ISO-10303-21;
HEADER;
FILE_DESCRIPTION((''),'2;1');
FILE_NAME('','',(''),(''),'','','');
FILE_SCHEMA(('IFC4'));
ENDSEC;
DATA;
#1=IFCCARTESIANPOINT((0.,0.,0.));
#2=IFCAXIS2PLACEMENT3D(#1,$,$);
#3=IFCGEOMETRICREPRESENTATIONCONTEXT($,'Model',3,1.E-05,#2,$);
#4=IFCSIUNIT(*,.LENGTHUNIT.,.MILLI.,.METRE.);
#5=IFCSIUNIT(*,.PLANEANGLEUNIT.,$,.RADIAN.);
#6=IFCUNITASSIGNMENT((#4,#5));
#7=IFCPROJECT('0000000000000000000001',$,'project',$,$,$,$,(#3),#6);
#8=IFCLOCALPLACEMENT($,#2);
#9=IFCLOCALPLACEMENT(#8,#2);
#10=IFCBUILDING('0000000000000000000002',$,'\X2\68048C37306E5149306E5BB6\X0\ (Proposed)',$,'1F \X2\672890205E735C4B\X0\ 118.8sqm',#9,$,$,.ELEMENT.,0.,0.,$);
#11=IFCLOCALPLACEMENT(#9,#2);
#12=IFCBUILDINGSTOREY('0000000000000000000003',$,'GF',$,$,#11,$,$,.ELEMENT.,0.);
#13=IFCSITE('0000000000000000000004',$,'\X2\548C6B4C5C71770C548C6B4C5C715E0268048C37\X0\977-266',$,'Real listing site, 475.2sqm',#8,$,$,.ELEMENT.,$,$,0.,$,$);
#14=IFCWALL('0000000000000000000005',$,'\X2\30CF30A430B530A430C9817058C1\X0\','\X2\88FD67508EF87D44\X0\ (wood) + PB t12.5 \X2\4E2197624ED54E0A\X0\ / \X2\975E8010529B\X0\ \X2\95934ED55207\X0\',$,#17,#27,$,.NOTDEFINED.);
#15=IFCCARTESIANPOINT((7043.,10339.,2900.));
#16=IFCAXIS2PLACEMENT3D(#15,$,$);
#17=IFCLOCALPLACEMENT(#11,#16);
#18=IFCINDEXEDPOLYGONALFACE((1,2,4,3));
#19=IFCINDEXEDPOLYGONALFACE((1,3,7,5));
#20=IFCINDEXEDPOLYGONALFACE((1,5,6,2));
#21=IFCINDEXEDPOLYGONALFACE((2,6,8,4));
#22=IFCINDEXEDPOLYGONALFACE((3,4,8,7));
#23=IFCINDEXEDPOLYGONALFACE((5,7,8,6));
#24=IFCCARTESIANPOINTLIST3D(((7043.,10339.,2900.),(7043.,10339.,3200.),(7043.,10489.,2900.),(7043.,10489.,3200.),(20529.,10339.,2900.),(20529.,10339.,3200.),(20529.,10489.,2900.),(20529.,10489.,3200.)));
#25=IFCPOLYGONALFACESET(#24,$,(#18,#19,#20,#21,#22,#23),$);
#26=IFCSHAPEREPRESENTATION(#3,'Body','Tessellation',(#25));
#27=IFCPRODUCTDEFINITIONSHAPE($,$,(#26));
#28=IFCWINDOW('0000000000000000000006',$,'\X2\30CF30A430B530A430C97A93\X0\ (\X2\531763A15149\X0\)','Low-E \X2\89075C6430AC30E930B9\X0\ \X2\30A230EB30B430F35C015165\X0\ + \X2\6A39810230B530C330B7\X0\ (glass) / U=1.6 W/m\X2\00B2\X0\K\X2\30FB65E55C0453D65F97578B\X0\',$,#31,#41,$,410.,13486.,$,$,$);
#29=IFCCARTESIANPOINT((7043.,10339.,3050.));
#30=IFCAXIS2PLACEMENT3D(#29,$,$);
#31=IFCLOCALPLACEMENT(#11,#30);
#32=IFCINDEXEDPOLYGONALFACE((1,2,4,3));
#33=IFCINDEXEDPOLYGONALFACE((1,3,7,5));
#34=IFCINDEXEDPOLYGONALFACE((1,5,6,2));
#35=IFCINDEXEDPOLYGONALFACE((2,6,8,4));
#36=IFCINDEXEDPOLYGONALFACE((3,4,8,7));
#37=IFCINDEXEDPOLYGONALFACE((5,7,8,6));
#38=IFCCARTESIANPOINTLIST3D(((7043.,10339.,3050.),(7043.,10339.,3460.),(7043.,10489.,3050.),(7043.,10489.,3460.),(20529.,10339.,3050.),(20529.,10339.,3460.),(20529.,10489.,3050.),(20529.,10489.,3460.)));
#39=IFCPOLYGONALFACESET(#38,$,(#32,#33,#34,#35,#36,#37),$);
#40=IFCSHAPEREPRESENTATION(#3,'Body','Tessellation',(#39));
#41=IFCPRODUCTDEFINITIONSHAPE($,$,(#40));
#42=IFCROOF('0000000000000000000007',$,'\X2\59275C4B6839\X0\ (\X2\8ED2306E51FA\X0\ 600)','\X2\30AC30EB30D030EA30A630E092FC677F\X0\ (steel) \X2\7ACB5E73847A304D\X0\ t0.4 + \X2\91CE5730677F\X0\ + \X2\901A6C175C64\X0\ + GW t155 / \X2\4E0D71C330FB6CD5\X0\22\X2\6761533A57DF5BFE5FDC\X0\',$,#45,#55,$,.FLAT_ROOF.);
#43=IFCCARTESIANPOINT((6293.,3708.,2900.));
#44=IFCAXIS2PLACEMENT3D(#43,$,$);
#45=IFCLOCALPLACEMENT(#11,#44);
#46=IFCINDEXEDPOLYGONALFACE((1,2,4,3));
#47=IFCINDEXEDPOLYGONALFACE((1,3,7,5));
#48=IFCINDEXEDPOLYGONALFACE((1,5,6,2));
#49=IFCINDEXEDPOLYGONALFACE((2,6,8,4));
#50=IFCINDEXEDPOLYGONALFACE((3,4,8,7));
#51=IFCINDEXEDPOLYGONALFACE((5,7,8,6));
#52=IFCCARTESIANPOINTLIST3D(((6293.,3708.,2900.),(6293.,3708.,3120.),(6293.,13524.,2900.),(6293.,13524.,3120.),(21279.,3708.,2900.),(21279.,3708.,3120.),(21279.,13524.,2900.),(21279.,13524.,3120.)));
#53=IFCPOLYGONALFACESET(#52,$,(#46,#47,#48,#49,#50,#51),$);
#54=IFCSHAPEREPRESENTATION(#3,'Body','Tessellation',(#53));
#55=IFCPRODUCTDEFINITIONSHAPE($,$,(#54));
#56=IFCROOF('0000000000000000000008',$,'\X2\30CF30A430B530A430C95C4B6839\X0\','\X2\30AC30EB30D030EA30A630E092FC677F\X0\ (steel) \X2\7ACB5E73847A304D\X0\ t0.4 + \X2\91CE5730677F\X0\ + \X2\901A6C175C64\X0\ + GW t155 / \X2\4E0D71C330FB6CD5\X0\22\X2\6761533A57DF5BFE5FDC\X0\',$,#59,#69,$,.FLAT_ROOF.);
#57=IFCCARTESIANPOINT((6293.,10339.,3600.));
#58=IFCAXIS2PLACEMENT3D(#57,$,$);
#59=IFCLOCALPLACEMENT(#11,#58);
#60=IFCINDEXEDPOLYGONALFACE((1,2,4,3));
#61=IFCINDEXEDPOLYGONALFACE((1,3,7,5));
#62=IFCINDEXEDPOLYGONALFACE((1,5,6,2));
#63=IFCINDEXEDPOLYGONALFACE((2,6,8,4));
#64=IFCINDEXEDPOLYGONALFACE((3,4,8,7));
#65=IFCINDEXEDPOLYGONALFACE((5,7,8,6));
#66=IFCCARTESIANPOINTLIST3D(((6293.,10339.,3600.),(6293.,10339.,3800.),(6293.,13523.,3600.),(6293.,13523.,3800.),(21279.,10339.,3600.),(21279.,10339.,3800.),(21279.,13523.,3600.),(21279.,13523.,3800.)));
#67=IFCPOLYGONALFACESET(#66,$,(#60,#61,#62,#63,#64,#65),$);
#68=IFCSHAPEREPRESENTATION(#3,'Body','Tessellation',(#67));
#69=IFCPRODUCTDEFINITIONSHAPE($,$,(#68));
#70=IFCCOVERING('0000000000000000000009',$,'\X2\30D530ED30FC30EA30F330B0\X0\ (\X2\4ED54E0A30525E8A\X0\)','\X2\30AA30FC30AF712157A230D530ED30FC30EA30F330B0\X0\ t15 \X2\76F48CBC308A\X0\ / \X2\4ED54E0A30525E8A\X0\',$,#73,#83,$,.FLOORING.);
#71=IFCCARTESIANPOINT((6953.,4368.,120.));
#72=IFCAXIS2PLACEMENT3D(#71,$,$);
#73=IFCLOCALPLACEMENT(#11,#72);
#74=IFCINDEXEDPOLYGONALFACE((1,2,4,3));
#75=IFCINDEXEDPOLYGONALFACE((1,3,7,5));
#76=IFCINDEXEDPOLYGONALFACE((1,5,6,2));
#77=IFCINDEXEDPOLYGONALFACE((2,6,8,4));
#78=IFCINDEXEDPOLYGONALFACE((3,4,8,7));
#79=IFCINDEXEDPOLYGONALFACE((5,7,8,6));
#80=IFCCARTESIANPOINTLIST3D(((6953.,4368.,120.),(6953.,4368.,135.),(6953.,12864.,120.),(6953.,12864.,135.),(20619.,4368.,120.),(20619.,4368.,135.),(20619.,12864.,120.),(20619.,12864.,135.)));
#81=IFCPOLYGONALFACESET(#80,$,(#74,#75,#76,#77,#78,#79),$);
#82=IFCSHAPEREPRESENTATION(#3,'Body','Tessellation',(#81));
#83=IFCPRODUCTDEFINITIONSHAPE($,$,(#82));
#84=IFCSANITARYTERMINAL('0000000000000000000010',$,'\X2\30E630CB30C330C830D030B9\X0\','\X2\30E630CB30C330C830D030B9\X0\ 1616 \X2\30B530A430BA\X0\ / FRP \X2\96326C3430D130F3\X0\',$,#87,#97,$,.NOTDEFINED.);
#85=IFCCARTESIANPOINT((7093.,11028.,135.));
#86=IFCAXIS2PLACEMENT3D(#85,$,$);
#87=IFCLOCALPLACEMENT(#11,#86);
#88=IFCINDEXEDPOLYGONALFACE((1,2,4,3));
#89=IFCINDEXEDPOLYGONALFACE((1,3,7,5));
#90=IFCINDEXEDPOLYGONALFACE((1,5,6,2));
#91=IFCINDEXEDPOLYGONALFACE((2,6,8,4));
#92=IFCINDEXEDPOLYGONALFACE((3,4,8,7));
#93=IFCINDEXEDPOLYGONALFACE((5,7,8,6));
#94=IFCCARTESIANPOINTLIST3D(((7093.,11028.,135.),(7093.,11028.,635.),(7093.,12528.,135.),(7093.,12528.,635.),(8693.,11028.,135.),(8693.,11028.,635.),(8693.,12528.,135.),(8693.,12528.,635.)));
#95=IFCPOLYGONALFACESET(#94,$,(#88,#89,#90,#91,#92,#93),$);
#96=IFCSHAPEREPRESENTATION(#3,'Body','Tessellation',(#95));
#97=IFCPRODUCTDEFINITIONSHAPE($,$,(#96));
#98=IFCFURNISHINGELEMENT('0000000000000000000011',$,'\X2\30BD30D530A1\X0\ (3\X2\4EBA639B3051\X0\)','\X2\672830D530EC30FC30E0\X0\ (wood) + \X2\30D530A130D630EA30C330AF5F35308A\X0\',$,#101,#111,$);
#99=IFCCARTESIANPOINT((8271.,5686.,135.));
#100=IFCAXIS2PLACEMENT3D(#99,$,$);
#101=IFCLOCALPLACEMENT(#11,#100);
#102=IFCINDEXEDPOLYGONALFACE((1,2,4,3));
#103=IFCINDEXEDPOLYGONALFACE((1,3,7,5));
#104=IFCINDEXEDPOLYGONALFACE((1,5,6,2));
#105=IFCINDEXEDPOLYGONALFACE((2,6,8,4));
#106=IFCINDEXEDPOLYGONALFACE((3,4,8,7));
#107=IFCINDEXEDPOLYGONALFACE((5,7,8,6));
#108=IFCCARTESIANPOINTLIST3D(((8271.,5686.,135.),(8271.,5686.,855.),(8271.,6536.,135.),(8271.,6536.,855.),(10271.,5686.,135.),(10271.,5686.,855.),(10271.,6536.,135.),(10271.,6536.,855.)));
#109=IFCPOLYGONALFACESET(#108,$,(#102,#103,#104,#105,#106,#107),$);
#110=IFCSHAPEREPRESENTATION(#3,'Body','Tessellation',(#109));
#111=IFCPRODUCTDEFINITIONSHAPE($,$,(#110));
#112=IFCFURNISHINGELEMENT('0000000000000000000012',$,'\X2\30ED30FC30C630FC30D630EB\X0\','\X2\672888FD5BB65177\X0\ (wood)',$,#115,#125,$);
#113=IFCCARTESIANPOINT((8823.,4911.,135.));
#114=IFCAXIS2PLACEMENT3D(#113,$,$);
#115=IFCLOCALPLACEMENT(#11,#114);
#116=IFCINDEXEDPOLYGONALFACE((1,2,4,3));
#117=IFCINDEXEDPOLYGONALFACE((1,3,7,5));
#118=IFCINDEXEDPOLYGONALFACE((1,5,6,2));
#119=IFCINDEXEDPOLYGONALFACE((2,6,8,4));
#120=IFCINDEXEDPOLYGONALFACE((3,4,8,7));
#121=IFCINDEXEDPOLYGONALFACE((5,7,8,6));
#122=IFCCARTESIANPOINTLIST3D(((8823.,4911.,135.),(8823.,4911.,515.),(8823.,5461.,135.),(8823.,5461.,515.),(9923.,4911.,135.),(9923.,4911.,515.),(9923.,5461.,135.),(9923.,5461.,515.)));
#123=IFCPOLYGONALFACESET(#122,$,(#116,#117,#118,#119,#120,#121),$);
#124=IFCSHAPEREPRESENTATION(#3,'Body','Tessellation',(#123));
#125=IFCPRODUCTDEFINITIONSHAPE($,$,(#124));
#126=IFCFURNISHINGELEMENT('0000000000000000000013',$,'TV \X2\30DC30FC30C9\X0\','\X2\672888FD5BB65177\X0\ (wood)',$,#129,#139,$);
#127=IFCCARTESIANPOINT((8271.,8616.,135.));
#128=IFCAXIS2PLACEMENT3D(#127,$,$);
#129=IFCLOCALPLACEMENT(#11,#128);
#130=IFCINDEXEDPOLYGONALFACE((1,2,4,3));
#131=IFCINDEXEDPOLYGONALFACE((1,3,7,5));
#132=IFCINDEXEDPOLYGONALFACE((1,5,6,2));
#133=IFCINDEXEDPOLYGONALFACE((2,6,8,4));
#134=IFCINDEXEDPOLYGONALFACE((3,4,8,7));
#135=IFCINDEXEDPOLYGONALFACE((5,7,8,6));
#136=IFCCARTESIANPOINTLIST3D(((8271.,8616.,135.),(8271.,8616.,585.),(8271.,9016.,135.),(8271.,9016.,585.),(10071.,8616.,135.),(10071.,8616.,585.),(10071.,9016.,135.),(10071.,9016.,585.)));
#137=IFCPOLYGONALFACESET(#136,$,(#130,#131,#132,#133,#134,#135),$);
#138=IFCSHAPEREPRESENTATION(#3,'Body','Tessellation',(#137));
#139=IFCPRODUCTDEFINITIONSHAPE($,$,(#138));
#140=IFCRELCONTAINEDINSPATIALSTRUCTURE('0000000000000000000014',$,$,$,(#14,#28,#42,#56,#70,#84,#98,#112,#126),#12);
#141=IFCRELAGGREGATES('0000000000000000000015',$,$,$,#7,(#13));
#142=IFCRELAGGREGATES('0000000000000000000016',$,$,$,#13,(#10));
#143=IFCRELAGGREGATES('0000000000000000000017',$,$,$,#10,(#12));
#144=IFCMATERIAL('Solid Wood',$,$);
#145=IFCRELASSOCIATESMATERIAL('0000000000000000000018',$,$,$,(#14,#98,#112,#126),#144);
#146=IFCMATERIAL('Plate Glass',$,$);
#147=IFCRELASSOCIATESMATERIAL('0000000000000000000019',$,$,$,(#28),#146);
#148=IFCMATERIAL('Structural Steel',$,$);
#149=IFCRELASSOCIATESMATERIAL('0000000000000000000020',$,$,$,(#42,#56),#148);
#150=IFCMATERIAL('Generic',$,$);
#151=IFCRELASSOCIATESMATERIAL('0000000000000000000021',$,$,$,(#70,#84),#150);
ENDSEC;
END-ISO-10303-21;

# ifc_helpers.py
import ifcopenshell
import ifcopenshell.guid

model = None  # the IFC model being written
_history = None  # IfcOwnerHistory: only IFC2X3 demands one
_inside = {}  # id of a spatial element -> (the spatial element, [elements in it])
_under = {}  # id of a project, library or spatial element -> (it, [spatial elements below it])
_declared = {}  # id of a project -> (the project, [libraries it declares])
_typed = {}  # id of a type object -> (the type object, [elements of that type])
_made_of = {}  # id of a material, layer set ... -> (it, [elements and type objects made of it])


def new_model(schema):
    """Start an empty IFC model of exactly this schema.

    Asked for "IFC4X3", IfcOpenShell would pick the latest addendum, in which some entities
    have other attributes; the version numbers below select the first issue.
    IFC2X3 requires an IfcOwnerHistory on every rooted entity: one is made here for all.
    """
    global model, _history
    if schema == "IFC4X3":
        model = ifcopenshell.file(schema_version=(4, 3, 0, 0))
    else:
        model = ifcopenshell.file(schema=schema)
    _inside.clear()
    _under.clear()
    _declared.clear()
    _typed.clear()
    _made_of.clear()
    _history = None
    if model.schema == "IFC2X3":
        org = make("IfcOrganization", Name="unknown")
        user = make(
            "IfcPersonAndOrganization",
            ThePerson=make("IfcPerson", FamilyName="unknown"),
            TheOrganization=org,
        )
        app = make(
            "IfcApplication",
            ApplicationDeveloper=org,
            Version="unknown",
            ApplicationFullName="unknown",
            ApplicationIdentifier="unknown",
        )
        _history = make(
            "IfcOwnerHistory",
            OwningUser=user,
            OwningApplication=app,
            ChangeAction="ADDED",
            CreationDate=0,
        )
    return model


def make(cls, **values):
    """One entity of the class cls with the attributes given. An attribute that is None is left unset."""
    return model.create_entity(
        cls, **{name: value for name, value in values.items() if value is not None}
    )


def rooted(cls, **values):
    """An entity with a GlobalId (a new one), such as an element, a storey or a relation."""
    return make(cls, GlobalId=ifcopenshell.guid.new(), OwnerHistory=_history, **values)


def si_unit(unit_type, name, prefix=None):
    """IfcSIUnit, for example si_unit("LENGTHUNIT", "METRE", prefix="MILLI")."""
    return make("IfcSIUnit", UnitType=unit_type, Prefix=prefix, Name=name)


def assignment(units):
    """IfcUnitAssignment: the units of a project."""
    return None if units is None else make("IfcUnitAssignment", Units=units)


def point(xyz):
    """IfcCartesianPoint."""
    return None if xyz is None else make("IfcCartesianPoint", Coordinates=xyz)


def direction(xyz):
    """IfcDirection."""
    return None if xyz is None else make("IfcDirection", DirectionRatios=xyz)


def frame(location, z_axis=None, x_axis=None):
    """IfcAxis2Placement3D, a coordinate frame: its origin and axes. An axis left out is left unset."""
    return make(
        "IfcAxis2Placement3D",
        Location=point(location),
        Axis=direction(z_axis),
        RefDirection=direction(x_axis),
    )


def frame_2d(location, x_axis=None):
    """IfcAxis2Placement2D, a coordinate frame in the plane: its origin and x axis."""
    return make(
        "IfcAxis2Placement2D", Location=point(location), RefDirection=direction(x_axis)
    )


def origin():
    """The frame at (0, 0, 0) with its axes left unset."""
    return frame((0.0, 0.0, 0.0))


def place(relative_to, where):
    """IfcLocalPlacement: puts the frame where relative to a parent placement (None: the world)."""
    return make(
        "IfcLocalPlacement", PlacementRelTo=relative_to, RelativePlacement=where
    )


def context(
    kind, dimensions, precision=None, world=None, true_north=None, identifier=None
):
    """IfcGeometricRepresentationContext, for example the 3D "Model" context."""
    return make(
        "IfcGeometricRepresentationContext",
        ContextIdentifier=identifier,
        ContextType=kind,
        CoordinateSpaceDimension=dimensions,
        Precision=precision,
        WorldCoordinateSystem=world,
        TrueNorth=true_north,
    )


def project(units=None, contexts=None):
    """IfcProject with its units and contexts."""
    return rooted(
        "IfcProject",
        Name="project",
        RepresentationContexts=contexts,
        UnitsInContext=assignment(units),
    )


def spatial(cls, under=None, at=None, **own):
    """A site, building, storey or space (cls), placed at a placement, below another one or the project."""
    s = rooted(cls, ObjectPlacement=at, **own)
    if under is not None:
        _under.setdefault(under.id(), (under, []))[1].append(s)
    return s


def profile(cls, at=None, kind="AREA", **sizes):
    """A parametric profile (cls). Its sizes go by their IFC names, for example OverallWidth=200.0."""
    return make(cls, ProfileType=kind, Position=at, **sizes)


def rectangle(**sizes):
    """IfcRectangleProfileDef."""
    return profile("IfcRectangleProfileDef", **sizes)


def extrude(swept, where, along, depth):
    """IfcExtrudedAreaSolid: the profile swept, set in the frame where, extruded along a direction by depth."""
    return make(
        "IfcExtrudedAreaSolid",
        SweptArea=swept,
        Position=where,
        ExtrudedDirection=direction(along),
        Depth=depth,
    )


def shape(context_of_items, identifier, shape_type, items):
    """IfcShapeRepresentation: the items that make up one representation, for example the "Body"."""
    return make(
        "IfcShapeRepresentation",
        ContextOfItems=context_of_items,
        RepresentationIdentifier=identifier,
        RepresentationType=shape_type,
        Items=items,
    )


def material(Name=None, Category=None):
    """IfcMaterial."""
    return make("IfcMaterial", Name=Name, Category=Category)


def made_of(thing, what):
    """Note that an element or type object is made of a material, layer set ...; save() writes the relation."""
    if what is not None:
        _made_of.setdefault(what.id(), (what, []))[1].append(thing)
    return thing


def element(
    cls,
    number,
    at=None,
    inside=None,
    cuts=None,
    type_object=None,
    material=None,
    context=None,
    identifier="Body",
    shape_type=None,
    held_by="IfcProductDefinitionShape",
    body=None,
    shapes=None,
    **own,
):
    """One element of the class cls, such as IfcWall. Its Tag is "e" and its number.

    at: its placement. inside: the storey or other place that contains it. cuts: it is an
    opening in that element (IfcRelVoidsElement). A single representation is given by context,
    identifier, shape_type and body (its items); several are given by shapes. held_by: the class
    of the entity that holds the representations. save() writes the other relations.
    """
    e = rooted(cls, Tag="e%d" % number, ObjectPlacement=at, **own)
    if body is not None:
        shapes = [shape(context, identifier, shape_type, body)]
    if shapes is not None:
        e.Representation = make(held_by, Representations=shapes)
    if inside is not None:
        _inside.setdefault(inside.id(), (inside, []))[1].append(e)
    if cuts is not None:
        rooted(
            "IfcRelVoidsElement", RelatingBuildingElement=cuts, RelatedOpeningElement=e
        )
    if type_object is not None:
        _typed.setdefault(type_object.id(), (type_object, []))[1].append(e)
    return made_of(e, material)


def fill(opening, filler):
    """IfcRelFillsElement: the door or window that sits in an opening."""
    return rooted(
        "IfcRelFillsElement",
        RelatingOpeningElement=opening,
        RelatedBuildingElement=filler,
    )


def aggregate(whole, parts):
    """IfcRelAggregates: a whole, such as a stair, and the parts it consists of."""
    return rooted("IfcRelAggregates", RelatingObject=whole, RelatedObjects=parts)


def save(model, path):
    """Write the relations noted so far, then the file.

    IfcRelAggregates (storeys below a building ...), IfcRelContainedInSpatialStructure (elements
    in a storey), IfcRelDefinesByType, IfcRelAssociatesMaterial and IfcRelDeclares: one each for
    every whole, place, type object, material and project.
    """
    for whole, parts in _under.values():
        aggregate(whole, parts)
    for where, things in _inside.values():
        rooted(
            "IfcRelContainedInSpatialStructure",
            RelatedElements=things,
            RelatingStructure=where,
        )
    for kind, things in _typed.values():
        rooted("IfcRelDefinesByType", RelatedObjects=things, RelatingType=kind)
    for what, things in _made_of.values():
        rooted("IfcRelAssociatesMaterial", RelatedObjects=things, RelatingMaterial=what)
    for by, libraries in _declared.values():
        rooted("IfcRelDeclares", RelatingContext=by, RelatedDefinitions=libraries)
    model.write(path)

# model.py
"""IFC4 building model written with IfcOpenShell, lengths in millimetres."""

from ifc_helpers import new_model, si_unit, frame, frame_2d, origin, place, context, project, spatial, rectangle, extrude, material, element, fill, save


model = new_model("IFC4")

# Units and contexts
model_context = context("Model", 3, precision=1e-05, world=origin())
ifc_project = project(units=[si_unit("LENGTHUNIT", "METRE", prefix="MILLI"), si_unit("PLANEANGLEUNIT", "RADIAN")], contexts=[model_context])

# Site, building, storey
site_placement = place(None, origin())
site = spatial("IfcSite", under=ifc_project, at=site_placement, Name="和歌山県和歌山市栄谷977-266", ObjectType="Real listing site, 475.2sqm", CompositionType="ELEMENT", RefElevation=0.0)
building_placement = place(site_placement, origin())
building = spatial("IfcBuilding", under=site, at=building_placement, Name="栄谷の光の家 (Proposed)", ObjectType="1F 木造平屋 118.8sqm", CompositionType="ELEMENT", ElevationOfRefHeight=0.0, ElevationOfTerrain=0.0)
storey_placement = place(building_placement, origin())
storey = spatial("IfcBuildingStorey", under=building, at=storey_placement, Name="GF", CompositionType="ELEMENT", Elevation=0.0)

# Shared definitions
ifc_material_1 = material(Name="Solid Wood")

# Shared definitions
ifc_material_2 = material(Name="Plate Glass")

# Wall, opening, window
wall_1_placement = place(storey_placement, frame((7043.0, 10339.0, 2900.0)))
wall_1 = element("IfcWall", 1, at=wall_1_placement, inside=storey, material=ifc_material_1, Name="ハイサイド腰壁", Description="製材軸組 (wood) + PB t12.5 両面仕上 / 非耐力 間仕切", PredefinedType="NOTDEFINED", context=model_context, shape_type="SweptSolid", body=[
    extrude(rectangle(XDim=13486.0, YDim=150.0, at=frame_2d((6743.0, 75.0))), frame((7043.0, 10339.0, 2900.0)), (0.0, 0.0, 1.0), 700.0),
])
opening_1_placement = place(storey_placement, frame((7043.0, 10339.0, 3050.0)))
opening_1 = element("IfcOpeningElement", 2, at=opening_1_placement, cuts=wall_1, PredefinedType="NOTDEFINED", context=model_context, shape_type="SweptSolid", body=[
    extrude(rectangle(XDim=13486.0, YDim=150.0, at=frame_2d((6743.0, 75.0))), frame((7043.0, 10339.0, 3050.0)), (0.0, 0.0, 1.0), 410.0),
])
window_1_placement = place(storey_placement, frame((7043.0, 10339.0, 3050.0)))
window_1 = element("IfcWindow", 3, at=window_1_placement, inside=storey, material=ifc_material_2, Name="ハイサイド窓 (北採光)", Description="Low-E 複層ガラス アルゴン封入 + 樹脂サッシ (glass) / U=1.6 W/m²K・日射取得型", OverallHeight=410.0, OverallWidth=13486.0, context=model_context, shape_type="SweptSolid", body=[
    extrude(rectangle(XDim=13486.0, YDim=150.0, at=frame_2d((6743.0, 75.0))), frame((7043.0, 10339.0, 3050.0)), (0.0, 0.0, 1.0), 410.0),
])
fill(opening_1, window_1)

# Roofs
ifc_material_3 = material(Name="Structural Steel")
roof_1_placement = place(storey_placement, frame((6293.0, 3708.0, 2900.0)))
element("IfcRoof", 4, at=roof_1_placement, inside=storey, material=ifc_material_3, Name="大屋根 (軒の出 600)", Description="ガルバリウム鋼板 (steel) 立平葺き t0.4 + 野地板 + 通気層 + GW t155 / 不燃・法22条区域対応", PredefinedType="FLAT_ROOF", context=model_context, shape_type="SweptSolid", body=[
    extrude(rectangle(XDim=14986.0, YDim=9816.0, at=frame_2d((7493.0, 4908.0))), frame((6293.0, 3708.0, 2900.0)), (0.0, 0.0, 1.0), 220.0),
])
roof_2_placement = place(storey_placement, frame((6293.0, 10339.0, 3600.0)))
element("IfcRoof", 5, at=roof_2_placement, inside=storey, material=ifc_material_3, Name="ハイサイド屋根", Description="ガルバリウム鋼板 (steel) 立平葺き t0.4 + 野地板 + 通気層 + GW t155 / 不燃・法22条区域対応", PredefinedType="FLAT_ROOF", context=model_context, shape_type="SweptSolid", body=[
    extrude(rectangle(XDim=14986.0, YDim=3184.0, at=frame_2d((7493.0, 1592.0))), frame((6293.0, 10339.0, 3600.0)), (0.0, 0.0, 1.0), 200.0),
])

# Covering
ifc_material_4 = material(Name="Generic")
covering_placement = place(storey_placement, frame((6953.0, 4368.0, 120.0)))
element("IfcCovering", 6, at=covering_placement, inside=storey, material=ifc_material_4, Name="フローリング (仕上げ床)", Description="オーク無垢フローリング t15 直貼り / 仕上げ床", PredefinedType="FLOORING", context=model_context, shape_type="SweptSolid", body=[
    extrude(rectangle(XDim=13666.0, YDim=8496.0, at=frame_2d((6833.0, 4248.0))), frame((6953.0, 4368.0, 120.0)), (0.0, 0.0, 1.0), 15.0),
])

# Sanitary terminal
sanitary_terminal_placement = place(storey_placement, frame((7093.0, 11028.0, 135.0)))
element("IfcSanitaryTerminal", 7, at=sanitary_terminal_placement, inside=storey, material=ifc_material_4, Name="ユニットバス", Description="ユニットバス 1616 サイズ / FRP 防水パン", PredefinedType="NOTDEFINED", context=model_context, shape_type="SweptSolid", body=[
    extrude(rectangle(XDim=1600.0, YDim=1500.0, at=frame_2d((800.0, 750.0))), frame((7093.0, 11028.0, 135.0)), (0.0, 0.0, 1.0), 500.0),
])

# Furnishing elements
furnishing_1_placement = place(storey_placement, frame((8271.0, 5686.0, 135.0)))
element("IfcFurnishingElement", 8, at=furnishing_1_placement, inside=storey, material=ifc_material_1, Name="ソファ (3人掛け)", Description="木フレーム (wood) + ファブリック張り", context=model_context, shape_type="SweptSolid", body=[
    extrude(rectangle(XDim=2000.0, YDim=850.0, at=frame_2d((1000.0, 425.0))), frame((8271.0, 5686.0, 135.0)), (0.0, 0.0, 1.0), 720.0),
])
furnishing_2_placement = place(storey_placement, frame((8823.0, 4911.0, 135.0)))
element("IfcFurnishingElement", 9, at=furnishing_2_placement, inside=storey, material=ifc_material_1, Name="ローテーブル", Description="木製家具 (wood)", context=model_context, shape_type="SweptSolid", body=[
    extrude(rectangle(XDim=1100.0, YDim=550.0, at=frame_2d((550.0, 275.0))), frame((8823.0, 4911.0, 135.0)), (0.0, 0.0, 1.0), 380.0),
])
furnishing_3_placement = place(storey_placement, frame((8271.0, 8616.0, 135.0)))
element("IfcFurnishingElement", 10, at=furnishing_3_placement, inside=storey, material=ifc_material_1, Name="TV ボード", Description="木製家具 (wood)", context=model_context, shape_type="SweptSolid", body=[
    extrude(rectangle(XDim=1800.0, YDim=400.0, at=frame_2d((900.0, 200.0))), frame((8271.0, 8616.0, 135.0)), (0.0, 0.0, 1.0), 450.0),
])

save(model, "model.ifc")
